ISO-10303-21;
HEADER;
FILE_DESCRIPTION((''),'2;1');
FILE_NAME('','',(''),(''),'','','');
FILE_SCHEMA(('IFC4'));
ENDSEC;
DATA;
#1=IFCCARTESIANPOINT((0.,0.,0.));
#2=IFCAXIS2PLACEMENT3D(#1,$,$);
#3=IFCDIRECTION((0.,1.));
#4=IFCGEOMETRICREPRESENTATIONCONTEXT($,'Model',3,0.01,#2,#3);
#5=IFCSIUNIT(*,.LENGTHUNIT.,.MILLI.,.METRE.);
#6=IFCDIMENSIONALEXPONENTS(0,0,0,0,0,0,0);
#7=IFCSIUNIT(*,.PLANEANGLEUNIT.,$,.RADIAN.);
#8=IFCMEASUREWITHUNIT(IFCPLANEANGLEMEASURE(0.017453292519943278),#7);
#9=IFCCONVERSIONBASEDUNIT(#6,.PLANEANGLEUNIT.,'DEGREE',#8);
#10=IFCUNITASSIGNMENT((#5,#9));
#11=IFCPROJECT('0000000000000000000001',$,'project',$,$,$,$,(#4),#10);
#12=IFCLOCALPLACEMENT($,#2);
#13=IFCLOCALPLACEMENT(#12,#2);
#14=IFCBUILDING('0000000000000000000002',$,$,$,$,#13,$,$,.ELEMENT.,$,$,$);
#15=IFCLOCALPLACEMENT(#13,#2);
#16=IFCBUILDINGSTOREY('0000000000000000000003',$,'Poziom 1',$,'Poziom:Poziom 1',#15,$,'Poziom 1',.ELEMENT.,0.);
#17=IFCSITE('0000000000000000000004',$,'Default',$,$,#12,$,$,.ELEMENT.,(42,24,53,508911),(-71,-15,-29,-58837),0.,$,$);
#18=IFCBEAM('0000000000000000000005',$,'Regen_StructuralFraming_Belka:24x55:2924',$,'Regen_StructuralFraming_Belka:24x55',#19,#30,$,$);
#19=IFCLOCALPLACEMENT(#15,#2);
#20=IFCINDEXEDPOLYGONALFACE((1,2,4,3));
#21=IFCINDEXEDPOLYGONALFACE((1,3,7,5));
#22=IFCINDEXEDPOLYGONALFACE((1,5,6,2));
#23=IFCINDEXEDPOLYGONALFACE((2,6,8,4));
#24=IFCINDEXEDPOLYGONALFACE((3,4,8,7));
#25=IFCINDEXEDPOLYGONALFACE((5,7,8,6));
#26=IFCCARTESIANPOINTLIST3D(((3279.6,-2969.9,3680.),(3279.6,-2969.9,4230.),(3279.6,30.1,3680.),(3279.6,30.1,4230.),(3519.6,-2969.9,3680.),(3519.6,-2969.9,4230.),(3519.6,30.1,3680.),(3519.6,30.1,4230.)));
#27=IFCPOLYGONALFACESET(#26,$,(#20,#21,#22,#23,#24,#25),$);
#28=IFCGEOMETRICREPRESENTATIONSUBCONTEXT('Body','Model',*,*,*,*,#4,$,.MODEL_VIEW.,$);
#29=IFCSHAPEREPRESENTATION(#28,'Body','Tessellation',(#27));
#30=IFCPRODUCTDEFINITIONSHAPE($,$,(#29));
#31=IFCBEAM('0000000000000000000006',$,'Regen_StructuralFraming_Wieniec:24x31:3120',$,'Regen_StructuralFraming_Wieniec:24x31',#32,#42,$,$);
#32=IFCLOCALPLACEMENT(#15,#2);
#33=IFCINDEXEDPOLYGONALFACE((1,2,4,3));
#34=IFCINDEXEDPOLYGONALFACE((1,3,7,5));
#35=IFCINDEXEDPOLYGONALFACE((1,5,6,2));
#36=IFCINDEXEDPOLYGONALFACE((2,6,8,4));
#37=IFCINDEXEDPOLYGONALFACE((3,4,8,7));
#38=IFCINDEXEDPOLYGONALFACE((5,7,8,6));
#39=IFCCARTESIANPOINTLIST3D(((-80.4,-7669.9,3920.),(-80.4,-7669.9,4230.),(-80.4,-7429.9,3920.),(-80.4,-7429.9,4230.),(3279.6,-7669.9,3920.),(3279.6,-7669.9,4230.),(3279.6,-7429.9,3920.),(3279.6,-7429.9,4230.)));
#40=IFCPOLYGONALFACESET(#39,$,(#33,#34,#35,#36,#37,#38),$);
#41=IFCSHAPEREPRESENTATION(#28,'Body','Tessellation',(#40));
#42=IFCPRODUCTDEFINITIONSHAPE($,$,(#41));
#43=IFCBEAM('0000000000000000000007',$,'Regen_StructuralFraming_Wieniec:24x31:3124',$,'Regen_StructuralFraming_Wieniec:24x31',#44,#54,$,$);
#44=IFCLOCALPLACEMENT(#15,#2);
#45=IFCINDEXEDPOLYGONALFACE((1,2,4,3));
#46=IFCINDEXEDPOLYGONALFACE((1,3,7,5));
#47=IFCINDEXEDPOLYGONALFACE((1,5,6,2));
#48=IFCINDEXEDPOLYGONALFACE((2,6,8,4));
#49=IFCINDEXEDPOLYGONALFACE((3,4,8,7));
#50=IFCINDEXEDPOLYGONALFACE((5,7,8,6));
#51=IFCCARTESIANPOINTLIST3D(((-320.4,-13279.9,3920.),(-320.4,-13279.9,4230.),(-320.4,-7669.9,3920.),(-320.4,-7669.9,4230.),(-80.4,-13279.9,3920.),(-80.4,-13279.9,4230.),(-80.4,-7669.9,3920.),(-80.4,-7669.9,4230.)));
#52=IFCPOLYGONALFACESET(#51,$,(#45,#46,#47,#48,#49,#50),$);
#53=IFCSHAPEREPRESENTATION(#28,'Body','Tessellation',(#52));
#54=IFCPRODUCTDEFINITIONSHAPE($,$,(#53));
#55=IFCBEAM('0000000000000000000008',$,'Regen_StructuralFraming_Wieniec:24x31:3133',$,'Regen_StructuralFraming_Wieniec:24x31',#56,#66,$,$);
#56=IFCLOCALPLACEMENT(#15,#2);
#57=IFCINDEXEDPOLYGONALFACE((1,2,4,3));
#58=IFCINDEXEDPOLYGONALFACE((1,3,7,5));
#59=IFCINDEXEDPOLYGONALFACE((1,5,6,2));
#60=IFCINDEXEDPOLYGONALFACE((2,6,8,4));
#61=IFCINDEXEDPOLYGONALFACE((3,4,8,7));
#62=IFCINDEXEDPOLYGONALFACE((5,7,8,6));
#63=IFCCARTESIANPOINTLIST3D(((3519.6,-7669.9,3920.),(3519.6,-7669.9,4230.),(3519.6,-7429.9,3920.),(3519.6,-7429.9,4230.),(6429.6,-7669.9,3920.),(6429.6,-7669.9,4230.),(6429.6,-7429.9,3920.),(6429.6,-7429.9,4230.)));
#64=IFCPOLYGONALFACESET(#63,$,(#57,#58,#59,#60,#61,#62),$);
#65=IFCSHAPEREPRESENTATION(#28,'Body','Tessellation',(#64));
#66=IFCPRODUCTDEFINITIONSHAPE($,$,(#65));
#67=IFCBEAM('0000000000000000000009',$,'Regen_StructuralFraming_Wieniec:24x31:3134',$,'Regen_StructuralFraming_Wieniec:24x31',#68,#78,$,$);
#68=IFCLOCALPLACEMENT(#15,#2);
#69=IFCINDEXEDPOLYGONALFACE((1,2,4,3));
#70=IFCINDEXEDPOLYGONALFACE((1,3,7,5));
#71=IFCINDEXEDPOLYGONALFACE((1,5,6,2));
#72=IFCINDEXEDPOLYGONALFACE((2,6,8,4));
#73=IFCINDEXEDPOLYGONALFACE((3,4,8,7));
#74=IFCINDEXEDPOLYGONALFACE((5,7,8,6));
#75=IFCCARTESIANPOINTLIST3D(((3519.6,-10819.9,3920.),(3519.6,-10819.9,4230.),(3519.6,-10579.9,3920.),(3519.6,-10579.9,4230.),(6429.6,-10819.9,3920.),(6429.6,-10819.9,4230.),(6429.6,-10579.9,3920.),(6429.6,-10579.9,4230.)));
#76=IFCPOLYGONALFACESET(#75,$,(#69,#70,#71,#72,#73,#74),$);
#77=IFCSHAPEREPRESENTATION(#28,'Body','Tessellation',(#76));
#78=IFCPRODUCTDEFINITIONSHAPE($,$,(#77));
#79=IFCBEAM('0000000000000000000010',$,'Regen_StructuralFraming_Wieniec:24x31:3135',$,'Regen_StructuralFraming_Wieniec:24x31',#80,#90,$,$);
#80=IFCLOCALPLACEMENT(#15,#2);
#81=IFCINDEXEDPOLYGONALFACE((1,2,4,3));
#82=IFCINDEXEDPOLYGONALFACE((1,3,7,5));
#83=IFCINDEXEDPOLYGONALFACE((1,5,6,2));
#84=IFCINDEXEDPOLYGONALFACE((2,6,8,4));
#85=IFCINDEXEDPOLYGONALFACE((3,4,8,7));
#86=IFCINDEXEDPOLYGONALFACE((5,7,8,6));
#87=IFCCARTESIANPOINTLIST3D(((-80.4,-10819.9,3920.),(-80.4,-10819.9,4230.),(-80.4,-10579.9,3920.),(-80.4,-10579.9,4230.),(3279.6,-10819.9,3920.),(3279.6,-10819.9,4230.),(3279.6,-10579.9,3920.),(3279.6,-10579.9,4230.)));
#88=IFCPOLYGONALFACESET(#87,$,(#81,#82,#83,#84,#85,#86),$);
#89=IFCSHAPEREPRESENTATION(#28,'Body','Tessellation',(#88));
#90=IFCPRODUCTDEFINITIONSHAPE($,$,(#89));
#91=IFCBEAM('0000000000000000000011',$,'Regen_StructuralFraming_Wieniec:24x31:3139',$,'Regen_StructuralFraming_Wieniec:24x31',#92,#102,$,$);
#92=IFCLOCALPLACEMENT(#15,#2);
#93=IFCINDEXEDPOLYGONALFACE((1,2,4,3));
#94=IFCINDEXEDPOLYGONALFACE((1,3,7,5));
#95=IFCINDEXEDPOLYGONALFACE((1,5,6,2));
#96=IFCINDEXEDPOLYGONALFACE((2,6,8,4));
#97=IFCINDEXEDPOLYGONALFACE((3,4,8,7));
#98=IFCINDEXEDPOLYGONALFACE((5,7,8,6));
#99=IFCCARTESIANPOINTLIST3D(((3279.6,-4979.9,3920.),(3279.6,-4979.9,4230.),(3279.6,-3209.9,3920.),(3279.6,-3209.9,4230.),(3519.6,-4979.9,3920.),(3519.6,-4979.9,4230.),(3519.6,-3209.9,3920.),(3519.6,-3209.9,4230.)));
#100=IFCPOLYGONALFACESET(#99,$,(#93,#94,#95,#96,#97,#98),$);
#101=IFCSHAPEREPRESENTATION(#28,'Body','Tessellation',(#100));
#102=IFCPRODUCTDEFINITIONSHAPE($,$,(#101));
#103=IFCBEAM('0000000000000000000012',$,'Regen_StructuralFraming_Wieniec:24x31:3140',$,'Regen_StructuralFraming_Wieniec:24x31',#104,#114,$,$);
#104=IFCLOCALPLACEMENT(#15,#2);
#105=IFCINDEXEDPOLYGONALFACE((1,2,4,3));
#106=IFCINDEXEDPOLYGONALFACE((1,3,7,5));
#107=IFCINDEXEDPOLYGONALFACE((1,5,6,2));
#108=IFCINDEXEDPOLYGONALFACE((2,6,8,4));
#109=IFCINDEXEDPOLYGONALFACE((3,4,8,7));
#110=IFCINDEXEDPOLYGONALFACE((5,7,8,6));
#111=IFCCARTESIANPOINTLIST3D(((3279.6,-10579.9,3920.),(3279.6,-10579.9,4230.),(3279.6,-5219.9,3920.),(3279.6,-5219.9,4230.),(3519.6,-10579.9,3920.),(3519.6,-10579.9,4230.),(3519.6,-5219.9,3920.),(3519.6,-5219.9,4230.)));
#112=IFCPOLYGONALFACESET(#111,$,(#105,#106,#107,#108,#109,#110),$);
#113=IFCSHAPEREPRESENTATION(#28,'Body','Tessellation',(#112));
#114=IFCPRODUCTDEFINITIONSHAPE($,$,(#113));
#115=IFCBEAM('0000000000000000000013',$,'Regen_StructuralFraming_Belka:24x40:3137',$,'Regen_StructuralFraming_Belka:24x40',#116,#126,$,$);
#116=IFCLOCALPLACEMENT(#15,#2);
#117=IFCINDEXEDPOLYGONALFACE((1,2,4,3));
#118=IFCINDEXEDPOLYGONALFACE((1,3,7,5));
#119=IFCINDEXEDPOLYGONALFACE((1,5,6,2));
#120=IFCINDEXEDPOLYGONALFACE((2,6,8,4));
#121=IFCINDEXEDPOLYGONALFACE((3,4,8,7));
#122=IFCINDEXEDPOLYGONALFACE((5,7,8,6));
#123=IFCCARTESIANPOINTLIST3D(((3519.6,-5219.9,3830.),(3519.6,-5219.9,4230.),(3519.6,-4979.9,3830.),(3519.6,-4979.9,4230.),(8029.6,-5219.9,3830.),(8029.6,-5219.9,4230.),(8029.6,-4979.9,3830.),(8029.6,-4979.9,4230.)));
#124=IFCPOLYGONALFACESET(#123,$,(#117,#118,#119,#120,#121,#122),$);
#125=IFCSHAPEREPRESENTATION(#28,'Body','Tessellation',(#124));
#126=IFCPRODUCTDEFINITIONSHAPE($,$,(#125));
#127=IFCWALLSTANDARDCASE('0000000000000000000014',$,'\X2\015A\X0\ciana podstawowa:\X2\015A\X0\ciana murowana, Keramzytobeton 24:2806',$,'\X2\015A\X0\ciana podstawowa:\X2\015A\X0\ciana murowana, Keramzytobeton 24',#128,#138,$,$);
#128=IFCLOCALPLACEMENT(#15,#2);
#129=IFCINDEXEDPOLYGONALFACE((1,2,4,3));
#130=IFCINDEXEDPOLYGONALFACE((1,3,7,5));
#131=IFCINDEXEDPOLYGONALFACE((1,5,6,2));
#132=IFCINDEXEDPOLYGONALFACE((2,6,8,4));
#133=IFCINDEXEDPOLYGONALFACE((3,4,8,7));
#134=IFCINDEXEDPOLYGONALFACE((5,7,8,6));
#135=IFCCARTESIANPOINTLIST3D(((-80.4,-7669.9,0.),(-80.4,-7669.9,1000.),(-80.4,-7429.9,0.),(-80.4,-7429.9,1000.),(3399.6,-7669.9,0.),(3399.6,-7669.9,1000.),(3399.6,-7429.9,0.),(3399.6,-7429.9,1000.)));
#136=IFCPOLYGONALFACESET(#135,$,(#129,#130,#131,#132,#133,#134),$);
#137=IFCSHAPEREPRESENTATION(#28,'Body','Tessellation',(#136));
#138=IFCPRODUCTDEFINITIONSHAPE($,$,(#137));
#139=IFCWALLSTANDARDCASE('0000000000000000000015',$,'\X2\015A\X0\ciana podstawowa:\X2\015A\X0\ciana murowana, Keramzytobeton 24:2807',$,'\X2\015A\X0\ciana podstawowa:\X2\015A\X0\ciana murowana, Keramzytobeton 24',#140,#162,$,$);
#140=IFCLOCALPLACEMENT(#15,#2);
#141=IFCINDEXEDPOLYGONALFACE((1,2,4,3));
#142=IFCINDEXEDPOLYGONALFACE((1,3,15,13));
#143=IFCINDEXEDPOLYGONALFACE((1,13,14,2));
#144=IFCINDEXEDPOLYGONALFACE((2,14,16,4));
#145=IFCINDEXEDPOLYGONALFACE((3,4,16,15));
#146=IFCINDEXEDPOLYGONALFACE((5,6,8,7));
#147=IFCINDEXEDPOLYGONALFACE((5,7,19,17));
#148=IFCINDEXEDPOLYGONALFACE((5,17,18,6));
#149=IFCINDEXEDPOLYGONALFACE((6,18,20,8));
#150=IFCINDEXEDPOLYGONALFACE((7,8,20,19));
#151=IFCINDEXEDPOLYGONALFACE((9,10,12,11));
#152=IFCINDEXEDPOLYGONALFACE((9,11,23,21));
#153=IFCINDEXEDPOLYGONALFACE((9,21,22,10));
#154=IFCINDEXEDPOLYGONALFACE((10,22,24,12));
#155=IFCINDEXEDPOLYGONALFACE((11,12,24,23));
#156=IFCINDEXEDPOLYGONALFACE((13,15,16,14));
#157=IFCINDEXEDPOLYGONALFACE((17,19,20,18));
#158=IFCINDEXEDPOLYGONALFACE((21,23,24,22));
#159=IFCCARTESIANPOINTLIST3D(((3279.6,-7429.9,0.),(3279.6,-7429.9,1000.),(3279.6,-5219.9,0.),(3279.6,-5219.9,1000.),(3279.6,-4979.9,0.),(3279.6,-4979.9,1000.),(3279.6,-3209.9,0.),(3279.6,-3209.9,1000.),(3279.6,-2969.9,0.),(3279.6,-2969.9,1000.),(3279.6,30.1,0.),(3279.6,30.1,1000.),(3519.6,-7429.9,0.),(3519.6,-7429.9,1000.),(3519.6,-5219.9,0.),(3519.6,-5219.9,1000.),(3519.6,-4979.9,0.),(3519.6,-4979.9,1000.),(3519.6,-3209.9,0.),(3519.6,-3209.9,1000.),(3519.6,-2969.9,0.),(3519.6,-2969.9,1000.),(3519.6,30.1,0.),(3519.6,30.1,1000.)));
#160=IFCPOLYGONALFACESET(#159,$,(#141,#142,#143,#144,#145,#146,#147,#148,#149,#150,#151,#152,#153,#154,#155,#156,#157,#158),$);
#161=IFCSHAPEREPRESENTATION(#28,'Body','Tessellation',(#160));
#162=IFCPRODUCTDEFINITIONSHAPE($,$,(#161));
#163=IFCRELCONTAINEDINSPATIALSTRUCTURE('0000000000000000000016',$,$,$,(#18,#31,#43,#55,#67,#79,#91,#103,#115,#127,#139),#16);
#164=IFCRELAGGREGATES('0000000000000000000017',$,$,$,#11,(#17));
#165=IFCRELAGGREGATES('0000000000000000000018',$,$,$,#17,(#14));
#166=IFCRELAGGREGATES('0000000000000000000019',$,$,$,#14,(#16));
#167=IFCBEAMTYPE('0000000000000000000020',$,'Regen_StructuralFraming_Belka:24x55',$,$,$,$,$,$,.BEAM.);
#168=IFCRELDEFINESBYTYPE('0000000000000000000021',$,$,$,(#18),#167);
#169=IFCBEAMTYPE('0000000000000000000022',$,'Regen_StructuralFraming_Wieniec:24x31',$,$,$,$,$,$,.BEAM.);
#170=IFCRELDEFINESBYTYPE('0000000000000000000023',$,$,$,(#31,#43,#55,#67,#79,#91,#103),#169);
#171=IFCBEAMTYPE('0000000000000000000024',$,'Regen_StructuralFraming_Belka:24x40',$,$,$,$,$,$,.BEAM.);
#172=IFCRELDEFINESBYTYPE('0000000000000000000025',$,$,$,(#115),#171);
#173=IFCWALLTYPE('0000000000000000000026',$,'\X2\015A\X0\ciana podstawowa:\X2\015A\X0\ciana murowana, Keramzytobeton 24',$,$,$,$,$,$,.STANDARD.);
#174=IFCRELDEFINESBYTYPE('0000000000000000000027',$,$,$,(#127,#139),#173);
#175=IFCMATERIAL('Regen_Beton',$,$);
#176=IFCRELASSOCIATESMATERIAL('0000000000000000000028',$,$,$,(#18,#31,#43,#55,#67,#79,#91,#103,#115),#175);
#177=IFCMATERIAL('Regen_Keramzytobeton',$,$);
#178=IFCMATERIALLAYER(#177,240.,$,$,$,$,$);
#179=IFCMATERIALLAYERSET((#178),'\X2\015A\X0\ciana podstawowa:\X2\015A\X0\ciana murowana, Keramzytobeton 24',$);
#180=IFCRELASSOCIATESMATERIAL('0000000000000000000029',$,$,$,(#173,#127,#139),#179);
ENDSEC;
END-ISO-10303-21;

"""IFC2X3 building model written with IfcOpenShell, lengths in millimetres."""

from ifc_helpers import new_model, entity, si_unit, converted_unit, direction, frame, frame_2d, origin, place, context, subcontext, project, spatial, rectangle, extrude, material, layer, layer_set, layer_usage, type_object, element, save


model = new_model("IFC2X3")

# Units and contexts
model_context = context("Model", 3, precision=0.01, world=origin(), true_north=direction((0.0, 1.0)))
body_context = subcontext(model_context, "Body", "Model", "MODEL_VIEW")
ifc_project = project(units=[si_unit("LENGTHUNIT", "METRE", prefix="MILLI"), converted_unit("PLANEANGLEUNIT", "DEGREE", entity("IfcPlaneAngleMeasure", 0.017453292519943278), si_unit("PLANEANGLEUNIT", "RADIAN"), dimensions=[0, 0, 0, 0, 0, 0, 0])], contexts=[model_context])

# Site, building, storey
site_placement = place(None, origin())
site = spatial("IfcSite", under=ifc_project, at=site_placement, Name="Default", CompositionType="ELEMENT", RefLatitude=(42, 24, 53, 508911), RefLongitude=(-71, -15, -29, -58837), RefElevation=0.0)
building_placement = place(site_placement, origin())
building = spatial("IfcBuilding", under=site, at=building_placement, CompositionType="ELEMENT")
storey_placement = place(building_placement, origin())
storey = spatial("IfcBuildingStorey", under=building, at=storey_placement, Name="Poziom 1", ObjectType="Poziom:Poziom 1", LongName="Poziom 1", CompositionType="ELEMENT", Elevation=0.0)

# Beams
ifc_material_1 = material(Name="Regen_Beton")
beam_type_1 = type_object("IfcBeamType", Name="Regen_StructuralFraming_Belka:24x55", PredefinedType="BEAM")
beam_1_placement = place(storey_placement, frame((3399.6, -2969.9, 4230.0), z_axis=(0.0, 0.0, 1.0), x_axis=(0.0, 1.0, 0.0)))
element("IfcBeam", 1, at=beam_1_placement, inside=storey, type_object=beam_type_1, material=ifc_material_1, Name="Regen_StructuralFraming_Belka:24x55:2924", ObjectType="Regen_StructuralFraming_Belka:24x55", context=body_context, shape_type="SweptSolid", body=[
    extrude(rectangle(XDim=550.0, YDim=240.0, at=frame_2d((0.0, 0.0), x_axis=(1.0, 0.0))), frame((0.0, 0.0, -275.0), z_axis=(1.0, 0.0, 0.0), x_axis=(0.0, 0.0, -1.0)), (0.0, 0.0, 1.0), 3000.0),
])
beam_type_2 = type_object("IfcBeamType", Name="Regen_StructuralFraming_Wieniec:24x31", PredefinedType="BEAM")
beam_2_placement = place(storey_placement, frame((3279.6, -7549.9, 4230.0), z_axis=(0.0, 0.0, 1.0), x_axis=(-1.0, 0.0, 0.0)))
element("IfcBeam", 2, at=beam_2_placement, inside=storey, type_object=beam_type_2, material=ifc_material_1, Name="Regen_StructuralFraming_Wieniec:24x31:3120", ObjectType="Regen_StructuralFraming_Wieniec:24x31", context=body_context, shape_type="SweptSolid", body=[
    extrude(rectangle(XDim=310.0, YDim=240.0, at=frame_2d((0.0, 0.0), x_axis=(1.0, 0.0))), frame((0.0, 0.0, -155.0), z_axis=(1.0, 0.0, 0.0), x_axis=(0.0, 0.0, -1.0)), (0.0, 0.0, 1.0), 3360.0),
])
beam_3_placement = place(storey_placement, frame((-200.4, -13279.9, 4230.0), z_axis=(0.0, 0.0, 1.0), x_axis=(0.0, 1.0, 0.0)))
element("IfcBeam", 3, at=beam_3_placement, inside=storey, type_object=beam_type_2, material=ifc_material_1, Name="Regen_StructuralFraming_Wieniec:24x31:3124", ObjectType="Regen_StructuralFraming_Wieniec:24x31", context=body_context, shape_type="SweptSolid", body=[
    extrude(rectangle(XDim=310.0, YDim=240.0, at=frame_2d((0.0, 0.0), x_axis=(1.0, 0.0))), frame((0.0, 0.0, -155.0), z_axis=(1.0, 0.0, 0.0), x_axis=(0.0, 0.0, -1.0)), (0.0, 0.0, 1.0), 5610.0),
])
beam_4_placement = place(storey_placement, frame((6429.6, -7549.9, 4230.0), z_axis=(0.0, 0.0, 1.0), x_axis=(-1.0, 0.0, 0.0)))
element("IfcBeam", 4, at=beam_4_placement, inside=storey, type_object=beam_type_2, material=ifc_material_1, Name="Regen_StructuralFraming_Wieniec:24x31:3133", ObjectType="Regen_StructuralFraming_Wieniec:24x31", context=body_context, shape_type="SweptSolid", body=[
    extrude(rectangle(XDim=310.0, YDim=240.0, at=frame_2d((0.0, 0.0), x_axis=(1.0, 0.0))), frame((0.0, 0.0, -155.0), z_axis=(1.0, 0.0, 0.0), x_axis=(0.0, 0.0, -1.0)), (0.0, 0.0, 1.0), 2910.0),
])
beam_5_placement = place(storey_placement, frame((6429.6, -10699.9, 4230.0), z_axis=(0.0, 0.0, 1.0), x_axis=(-1.0, 0.0, 0.0)))
element("IfcBeam", 5, at=beam_5_placement, inside=storey, type_object=beam_type_2, material=ifc_material_1, Name="Regen_StructuralFraming_Wieniec:24x31:3134", ObjectType="Regen_StructuralFraming_Wieniec:24x31", context=body_context, shape_type="SweptSolid", body=[
    extrude(rectangle(XDim=310.0, YDim=240.0, at=frame_2d((0.0, 0.0), x_axis=(1.0, 0.0))), frame((0.0, 0.0, -155.0), z_axis=(1.0, 0.0, 0.0), x_axis=(0.0, 0.0, -1.0)), (0.0, 0.0, 1.0), 2910.0),
])
beam_6_placement = place(storey_placement, frame((3279.6, -10699.9, 4230.0), z_axis=(0.0, 0.0, 1.0), x_axis=(-1.0, 0.0, 0.0)))
element("IfcBeam", 6, at=beam_6_placement, inside=storey, type_object=beam_type_2, material=ifc_material_1, Name="Regen_StructuralFraming_Wieniec:24x31:3135", ObjectType="Regen_StructuralFraming_Wieniec:24x31", context=body_context, shape_type="SweptSolid", body=[
    extrude(rectangle(XDim=310.0, YDim=240.0, at=frame_2d((0.0, 0.0), x_axis=(1.0, 0.0))), frame((0.0, 0.0, -155.0), z_axis=(1.0, 0.0, 0.0), x_axis=(0.0, 0.0, -1.0)), (0.0, 0.0, 1.0), 3360.0),
])
beam_7_placement = place(storey_placement, frame((3399.6, -4979.9, 4230.0), z_axis=(0.0, 0.0, 1.0), x_axis=(0.0, 1.0, 0.0)))
element("IfcBeam", 7, at=beam_7_placement, inside=storey, type_object=beam_type_2, material=ifc_material_1, Name="Regen_StructuralFraming_Wieniec:24x31:3139", ObjectType="Regen_StructuralFraming_Wieniec:24x31", context=body_context, shape_type="SweptSolid", body=[
    extrude(rectangle(XDim=310.0, YDim=240.0, at=frame_2d((0.0, 0.0), x_axis=(1.0, 0.0))), frame((0.0, 0.0, -155.0), z_axis=(1.0, 0.0, 0.0), x_axis=(0.0, 0.0, -1.0)), (0.0, 0.0, 1.0), 1770.0),
])
beam_8_placement = place(storey_placement, frame((3399.6, -10579.9, 4230.0), z_axis=(0.0, 0.0, 1.0), x_axis=(0.0, 1.0, 0.0)))
element("IfcBeam", 8, at=beam_8_placement, inside=storey, type_object=beam_type_2, material=ifc_material_1, Name="Regen_StructuralFraming_Wieniec:24x31:3140", ObjectType="Regen_StructuralFraming_Wieniec:24x31", context=body_context, shape_type="SweptSolid", body=[
    extrude(rectangle(XDim=310.0, YDim=240.0, at=frame_2d((0.0, 0.0), x_axis=(1.0, 0.0))), frame((0.0, 0.0, -155.0), z_axis=(1.0, 0.0, 0.0), x_axis=(0.0, 0.0, -1.0)), (0.0, 0.0, 1.0), 5360.0),
])
beam_type_3 = type_object("IfcBeamType", Name="Regen_StructuralFraming_Belka:24x40", PredefinedType="BEAM")
beam_9_placement = place(storey_placement, frame((3519.6, -5099.9, 4230.0)))
element("IfcBeam", 9, at=beam_9_placement, inside=storey, type_object=beam_type_3, material=ifc_material_1, Name="Regen_StructuralFraming_Belka:24x40:3137", ObjectType="Regen_StructuralFraming_Belka:24x40", context=body_context, shape_type="SweptSolid", body=[
    extrude(rectangle(XDim=400.0, YDim=240.0, at=frame_2d((0.0, 0.0), x_axis=(1.0, 0.0))), frame((0.0, 0.0, -200.0), z_axis=(1.0, 0.0, 0.0), x_axis=(0.0, 0.0, -1.0)), (0.0, 0.0, 1.0), 4510.0),
])

# Wall
ifc_material_2 = material(Name="Regen_Keramzytobeton")
ifc_layer_1 = layer(ifc_material_2, 240.0)
ifc_layer_set_1 = layer_set([ifc_layer_1], Name="Ściana podstawowa:Ściana murowana, Keramzytobeton 24")
ifc_layer_usage_1 = layer_usage(ifc_layer_set_1, "AXIS2", "NEGATIVE", 120.0)
wall_type_1 = type_object("IfcWallType", Name="Ściana podstawowa:Ściana murowana, Keramzytobeton 24", PredefinedType="STANDARD", material=ifc_layer_set_1)
wall_1_placement = place(storey_placement, frame((-80.4, -7549.9, 0.0)))
element("IfcWallStandardCase", 10, at=wall_1_placement, inside=storey, type_object=wall_type_1, material=ifc_layer_usage_1, Name="Ściana podstawowa:Ściana murowana, Keramzytobeton 24:2806", ObjectType="Ściana podstawowa:Ściana murowana, Keramzytobeton 24", context=body_context, shape_type="SweptSolid", body=[
    extrude(rectangle(XDim=3480.0, YDim=240.0, at=frame_2d((1740.0, 0.0), x_axis=(-1.0, 0.0))), origin(), (0.0, 0.0, 1.0), 1000.0),
])

# Wall, openings
ifc_layer_usage_2 = layer_usage(ifc_layer_set_1, "AXIS2", "NEGATIVE", 120.0)
wall_2_placement = place(storey_placement, frame((3399.6, -7429.9, 0.0), z_axis=(0.0, 0.0, 1.0), x_axis=(0.0, 1.0, 0.0)))
wall_2 = element("IfcWallStandardCase", 11, at=wall_2_placement, inside=storey, type_object=wall_type_1, material=ifc_layer_usage_2, Name="Ściana podstawowa:Ściana murowana, Keramzytobeton 24:2807", ObjectType="Ściana podstawowa:Ściana murowana, Keramzytobeton 24", context=body_context, shape_type="SweptSolid", body=[
    extrude(rectangle(XDim=7460.0, YDim=240.0, at=frame_2d((3730.0, 0.0), x_axis=(-1.0, 0.0))), origin(), (0.0, 0.0, 1.0), 1000.0),
])
opening_1_placement = place(storey_placement, frame((3399.6, -7429.9, 0.0), z_axis=(0.0, 0.0, 1.0), x_axis=(0.0, 1.0, 0.0)))
element("IfcOpeningElement", 12, at=opening_1_placement, cuts=wall_2, ObjectType="Opening", context=body_context, shape_type="SweptSolid", body=[
    extrude(rectangle(XDim=1000.0, YDim=240.0, at=frame_2d((0.0, 0.0), x_axis=(1.0, 0.0))), frame((2210.0, 0.0, 500.0), z_axis=(1.0, 0.0, 0.0), x_axis=(0.0, 0.0, -1.0)), (0.0, 0.0, 1.0), 240.0),
])
opening_2_placement = place(storey_placement, frame((3399.6, -7429.9, 0.0), z_axis=(0.0, 0.0, 1.0), x_axis=(0.0, 1.0, 0.0)))
element("IfcOpeningElement", 13, at=opening_2_placement, cuts=wall_2, ObjectType="Opening", context=body_context, shape_type="SweptSolid", body=[
    extrude(rectangle(XDim=1000.0, YDim=240.0, at=frame_2d((0.0, 0.0), x_axis=(1.0, 0.0))), frame((4220.0, 0.0, 500.0), z_axis=(1.0, 0.0, 0.0), x_axis=(0.0, 0.0, -1.0)), (0.0, 0.0, 1.0), 240.0),
])

save(model, "model.ifc")
